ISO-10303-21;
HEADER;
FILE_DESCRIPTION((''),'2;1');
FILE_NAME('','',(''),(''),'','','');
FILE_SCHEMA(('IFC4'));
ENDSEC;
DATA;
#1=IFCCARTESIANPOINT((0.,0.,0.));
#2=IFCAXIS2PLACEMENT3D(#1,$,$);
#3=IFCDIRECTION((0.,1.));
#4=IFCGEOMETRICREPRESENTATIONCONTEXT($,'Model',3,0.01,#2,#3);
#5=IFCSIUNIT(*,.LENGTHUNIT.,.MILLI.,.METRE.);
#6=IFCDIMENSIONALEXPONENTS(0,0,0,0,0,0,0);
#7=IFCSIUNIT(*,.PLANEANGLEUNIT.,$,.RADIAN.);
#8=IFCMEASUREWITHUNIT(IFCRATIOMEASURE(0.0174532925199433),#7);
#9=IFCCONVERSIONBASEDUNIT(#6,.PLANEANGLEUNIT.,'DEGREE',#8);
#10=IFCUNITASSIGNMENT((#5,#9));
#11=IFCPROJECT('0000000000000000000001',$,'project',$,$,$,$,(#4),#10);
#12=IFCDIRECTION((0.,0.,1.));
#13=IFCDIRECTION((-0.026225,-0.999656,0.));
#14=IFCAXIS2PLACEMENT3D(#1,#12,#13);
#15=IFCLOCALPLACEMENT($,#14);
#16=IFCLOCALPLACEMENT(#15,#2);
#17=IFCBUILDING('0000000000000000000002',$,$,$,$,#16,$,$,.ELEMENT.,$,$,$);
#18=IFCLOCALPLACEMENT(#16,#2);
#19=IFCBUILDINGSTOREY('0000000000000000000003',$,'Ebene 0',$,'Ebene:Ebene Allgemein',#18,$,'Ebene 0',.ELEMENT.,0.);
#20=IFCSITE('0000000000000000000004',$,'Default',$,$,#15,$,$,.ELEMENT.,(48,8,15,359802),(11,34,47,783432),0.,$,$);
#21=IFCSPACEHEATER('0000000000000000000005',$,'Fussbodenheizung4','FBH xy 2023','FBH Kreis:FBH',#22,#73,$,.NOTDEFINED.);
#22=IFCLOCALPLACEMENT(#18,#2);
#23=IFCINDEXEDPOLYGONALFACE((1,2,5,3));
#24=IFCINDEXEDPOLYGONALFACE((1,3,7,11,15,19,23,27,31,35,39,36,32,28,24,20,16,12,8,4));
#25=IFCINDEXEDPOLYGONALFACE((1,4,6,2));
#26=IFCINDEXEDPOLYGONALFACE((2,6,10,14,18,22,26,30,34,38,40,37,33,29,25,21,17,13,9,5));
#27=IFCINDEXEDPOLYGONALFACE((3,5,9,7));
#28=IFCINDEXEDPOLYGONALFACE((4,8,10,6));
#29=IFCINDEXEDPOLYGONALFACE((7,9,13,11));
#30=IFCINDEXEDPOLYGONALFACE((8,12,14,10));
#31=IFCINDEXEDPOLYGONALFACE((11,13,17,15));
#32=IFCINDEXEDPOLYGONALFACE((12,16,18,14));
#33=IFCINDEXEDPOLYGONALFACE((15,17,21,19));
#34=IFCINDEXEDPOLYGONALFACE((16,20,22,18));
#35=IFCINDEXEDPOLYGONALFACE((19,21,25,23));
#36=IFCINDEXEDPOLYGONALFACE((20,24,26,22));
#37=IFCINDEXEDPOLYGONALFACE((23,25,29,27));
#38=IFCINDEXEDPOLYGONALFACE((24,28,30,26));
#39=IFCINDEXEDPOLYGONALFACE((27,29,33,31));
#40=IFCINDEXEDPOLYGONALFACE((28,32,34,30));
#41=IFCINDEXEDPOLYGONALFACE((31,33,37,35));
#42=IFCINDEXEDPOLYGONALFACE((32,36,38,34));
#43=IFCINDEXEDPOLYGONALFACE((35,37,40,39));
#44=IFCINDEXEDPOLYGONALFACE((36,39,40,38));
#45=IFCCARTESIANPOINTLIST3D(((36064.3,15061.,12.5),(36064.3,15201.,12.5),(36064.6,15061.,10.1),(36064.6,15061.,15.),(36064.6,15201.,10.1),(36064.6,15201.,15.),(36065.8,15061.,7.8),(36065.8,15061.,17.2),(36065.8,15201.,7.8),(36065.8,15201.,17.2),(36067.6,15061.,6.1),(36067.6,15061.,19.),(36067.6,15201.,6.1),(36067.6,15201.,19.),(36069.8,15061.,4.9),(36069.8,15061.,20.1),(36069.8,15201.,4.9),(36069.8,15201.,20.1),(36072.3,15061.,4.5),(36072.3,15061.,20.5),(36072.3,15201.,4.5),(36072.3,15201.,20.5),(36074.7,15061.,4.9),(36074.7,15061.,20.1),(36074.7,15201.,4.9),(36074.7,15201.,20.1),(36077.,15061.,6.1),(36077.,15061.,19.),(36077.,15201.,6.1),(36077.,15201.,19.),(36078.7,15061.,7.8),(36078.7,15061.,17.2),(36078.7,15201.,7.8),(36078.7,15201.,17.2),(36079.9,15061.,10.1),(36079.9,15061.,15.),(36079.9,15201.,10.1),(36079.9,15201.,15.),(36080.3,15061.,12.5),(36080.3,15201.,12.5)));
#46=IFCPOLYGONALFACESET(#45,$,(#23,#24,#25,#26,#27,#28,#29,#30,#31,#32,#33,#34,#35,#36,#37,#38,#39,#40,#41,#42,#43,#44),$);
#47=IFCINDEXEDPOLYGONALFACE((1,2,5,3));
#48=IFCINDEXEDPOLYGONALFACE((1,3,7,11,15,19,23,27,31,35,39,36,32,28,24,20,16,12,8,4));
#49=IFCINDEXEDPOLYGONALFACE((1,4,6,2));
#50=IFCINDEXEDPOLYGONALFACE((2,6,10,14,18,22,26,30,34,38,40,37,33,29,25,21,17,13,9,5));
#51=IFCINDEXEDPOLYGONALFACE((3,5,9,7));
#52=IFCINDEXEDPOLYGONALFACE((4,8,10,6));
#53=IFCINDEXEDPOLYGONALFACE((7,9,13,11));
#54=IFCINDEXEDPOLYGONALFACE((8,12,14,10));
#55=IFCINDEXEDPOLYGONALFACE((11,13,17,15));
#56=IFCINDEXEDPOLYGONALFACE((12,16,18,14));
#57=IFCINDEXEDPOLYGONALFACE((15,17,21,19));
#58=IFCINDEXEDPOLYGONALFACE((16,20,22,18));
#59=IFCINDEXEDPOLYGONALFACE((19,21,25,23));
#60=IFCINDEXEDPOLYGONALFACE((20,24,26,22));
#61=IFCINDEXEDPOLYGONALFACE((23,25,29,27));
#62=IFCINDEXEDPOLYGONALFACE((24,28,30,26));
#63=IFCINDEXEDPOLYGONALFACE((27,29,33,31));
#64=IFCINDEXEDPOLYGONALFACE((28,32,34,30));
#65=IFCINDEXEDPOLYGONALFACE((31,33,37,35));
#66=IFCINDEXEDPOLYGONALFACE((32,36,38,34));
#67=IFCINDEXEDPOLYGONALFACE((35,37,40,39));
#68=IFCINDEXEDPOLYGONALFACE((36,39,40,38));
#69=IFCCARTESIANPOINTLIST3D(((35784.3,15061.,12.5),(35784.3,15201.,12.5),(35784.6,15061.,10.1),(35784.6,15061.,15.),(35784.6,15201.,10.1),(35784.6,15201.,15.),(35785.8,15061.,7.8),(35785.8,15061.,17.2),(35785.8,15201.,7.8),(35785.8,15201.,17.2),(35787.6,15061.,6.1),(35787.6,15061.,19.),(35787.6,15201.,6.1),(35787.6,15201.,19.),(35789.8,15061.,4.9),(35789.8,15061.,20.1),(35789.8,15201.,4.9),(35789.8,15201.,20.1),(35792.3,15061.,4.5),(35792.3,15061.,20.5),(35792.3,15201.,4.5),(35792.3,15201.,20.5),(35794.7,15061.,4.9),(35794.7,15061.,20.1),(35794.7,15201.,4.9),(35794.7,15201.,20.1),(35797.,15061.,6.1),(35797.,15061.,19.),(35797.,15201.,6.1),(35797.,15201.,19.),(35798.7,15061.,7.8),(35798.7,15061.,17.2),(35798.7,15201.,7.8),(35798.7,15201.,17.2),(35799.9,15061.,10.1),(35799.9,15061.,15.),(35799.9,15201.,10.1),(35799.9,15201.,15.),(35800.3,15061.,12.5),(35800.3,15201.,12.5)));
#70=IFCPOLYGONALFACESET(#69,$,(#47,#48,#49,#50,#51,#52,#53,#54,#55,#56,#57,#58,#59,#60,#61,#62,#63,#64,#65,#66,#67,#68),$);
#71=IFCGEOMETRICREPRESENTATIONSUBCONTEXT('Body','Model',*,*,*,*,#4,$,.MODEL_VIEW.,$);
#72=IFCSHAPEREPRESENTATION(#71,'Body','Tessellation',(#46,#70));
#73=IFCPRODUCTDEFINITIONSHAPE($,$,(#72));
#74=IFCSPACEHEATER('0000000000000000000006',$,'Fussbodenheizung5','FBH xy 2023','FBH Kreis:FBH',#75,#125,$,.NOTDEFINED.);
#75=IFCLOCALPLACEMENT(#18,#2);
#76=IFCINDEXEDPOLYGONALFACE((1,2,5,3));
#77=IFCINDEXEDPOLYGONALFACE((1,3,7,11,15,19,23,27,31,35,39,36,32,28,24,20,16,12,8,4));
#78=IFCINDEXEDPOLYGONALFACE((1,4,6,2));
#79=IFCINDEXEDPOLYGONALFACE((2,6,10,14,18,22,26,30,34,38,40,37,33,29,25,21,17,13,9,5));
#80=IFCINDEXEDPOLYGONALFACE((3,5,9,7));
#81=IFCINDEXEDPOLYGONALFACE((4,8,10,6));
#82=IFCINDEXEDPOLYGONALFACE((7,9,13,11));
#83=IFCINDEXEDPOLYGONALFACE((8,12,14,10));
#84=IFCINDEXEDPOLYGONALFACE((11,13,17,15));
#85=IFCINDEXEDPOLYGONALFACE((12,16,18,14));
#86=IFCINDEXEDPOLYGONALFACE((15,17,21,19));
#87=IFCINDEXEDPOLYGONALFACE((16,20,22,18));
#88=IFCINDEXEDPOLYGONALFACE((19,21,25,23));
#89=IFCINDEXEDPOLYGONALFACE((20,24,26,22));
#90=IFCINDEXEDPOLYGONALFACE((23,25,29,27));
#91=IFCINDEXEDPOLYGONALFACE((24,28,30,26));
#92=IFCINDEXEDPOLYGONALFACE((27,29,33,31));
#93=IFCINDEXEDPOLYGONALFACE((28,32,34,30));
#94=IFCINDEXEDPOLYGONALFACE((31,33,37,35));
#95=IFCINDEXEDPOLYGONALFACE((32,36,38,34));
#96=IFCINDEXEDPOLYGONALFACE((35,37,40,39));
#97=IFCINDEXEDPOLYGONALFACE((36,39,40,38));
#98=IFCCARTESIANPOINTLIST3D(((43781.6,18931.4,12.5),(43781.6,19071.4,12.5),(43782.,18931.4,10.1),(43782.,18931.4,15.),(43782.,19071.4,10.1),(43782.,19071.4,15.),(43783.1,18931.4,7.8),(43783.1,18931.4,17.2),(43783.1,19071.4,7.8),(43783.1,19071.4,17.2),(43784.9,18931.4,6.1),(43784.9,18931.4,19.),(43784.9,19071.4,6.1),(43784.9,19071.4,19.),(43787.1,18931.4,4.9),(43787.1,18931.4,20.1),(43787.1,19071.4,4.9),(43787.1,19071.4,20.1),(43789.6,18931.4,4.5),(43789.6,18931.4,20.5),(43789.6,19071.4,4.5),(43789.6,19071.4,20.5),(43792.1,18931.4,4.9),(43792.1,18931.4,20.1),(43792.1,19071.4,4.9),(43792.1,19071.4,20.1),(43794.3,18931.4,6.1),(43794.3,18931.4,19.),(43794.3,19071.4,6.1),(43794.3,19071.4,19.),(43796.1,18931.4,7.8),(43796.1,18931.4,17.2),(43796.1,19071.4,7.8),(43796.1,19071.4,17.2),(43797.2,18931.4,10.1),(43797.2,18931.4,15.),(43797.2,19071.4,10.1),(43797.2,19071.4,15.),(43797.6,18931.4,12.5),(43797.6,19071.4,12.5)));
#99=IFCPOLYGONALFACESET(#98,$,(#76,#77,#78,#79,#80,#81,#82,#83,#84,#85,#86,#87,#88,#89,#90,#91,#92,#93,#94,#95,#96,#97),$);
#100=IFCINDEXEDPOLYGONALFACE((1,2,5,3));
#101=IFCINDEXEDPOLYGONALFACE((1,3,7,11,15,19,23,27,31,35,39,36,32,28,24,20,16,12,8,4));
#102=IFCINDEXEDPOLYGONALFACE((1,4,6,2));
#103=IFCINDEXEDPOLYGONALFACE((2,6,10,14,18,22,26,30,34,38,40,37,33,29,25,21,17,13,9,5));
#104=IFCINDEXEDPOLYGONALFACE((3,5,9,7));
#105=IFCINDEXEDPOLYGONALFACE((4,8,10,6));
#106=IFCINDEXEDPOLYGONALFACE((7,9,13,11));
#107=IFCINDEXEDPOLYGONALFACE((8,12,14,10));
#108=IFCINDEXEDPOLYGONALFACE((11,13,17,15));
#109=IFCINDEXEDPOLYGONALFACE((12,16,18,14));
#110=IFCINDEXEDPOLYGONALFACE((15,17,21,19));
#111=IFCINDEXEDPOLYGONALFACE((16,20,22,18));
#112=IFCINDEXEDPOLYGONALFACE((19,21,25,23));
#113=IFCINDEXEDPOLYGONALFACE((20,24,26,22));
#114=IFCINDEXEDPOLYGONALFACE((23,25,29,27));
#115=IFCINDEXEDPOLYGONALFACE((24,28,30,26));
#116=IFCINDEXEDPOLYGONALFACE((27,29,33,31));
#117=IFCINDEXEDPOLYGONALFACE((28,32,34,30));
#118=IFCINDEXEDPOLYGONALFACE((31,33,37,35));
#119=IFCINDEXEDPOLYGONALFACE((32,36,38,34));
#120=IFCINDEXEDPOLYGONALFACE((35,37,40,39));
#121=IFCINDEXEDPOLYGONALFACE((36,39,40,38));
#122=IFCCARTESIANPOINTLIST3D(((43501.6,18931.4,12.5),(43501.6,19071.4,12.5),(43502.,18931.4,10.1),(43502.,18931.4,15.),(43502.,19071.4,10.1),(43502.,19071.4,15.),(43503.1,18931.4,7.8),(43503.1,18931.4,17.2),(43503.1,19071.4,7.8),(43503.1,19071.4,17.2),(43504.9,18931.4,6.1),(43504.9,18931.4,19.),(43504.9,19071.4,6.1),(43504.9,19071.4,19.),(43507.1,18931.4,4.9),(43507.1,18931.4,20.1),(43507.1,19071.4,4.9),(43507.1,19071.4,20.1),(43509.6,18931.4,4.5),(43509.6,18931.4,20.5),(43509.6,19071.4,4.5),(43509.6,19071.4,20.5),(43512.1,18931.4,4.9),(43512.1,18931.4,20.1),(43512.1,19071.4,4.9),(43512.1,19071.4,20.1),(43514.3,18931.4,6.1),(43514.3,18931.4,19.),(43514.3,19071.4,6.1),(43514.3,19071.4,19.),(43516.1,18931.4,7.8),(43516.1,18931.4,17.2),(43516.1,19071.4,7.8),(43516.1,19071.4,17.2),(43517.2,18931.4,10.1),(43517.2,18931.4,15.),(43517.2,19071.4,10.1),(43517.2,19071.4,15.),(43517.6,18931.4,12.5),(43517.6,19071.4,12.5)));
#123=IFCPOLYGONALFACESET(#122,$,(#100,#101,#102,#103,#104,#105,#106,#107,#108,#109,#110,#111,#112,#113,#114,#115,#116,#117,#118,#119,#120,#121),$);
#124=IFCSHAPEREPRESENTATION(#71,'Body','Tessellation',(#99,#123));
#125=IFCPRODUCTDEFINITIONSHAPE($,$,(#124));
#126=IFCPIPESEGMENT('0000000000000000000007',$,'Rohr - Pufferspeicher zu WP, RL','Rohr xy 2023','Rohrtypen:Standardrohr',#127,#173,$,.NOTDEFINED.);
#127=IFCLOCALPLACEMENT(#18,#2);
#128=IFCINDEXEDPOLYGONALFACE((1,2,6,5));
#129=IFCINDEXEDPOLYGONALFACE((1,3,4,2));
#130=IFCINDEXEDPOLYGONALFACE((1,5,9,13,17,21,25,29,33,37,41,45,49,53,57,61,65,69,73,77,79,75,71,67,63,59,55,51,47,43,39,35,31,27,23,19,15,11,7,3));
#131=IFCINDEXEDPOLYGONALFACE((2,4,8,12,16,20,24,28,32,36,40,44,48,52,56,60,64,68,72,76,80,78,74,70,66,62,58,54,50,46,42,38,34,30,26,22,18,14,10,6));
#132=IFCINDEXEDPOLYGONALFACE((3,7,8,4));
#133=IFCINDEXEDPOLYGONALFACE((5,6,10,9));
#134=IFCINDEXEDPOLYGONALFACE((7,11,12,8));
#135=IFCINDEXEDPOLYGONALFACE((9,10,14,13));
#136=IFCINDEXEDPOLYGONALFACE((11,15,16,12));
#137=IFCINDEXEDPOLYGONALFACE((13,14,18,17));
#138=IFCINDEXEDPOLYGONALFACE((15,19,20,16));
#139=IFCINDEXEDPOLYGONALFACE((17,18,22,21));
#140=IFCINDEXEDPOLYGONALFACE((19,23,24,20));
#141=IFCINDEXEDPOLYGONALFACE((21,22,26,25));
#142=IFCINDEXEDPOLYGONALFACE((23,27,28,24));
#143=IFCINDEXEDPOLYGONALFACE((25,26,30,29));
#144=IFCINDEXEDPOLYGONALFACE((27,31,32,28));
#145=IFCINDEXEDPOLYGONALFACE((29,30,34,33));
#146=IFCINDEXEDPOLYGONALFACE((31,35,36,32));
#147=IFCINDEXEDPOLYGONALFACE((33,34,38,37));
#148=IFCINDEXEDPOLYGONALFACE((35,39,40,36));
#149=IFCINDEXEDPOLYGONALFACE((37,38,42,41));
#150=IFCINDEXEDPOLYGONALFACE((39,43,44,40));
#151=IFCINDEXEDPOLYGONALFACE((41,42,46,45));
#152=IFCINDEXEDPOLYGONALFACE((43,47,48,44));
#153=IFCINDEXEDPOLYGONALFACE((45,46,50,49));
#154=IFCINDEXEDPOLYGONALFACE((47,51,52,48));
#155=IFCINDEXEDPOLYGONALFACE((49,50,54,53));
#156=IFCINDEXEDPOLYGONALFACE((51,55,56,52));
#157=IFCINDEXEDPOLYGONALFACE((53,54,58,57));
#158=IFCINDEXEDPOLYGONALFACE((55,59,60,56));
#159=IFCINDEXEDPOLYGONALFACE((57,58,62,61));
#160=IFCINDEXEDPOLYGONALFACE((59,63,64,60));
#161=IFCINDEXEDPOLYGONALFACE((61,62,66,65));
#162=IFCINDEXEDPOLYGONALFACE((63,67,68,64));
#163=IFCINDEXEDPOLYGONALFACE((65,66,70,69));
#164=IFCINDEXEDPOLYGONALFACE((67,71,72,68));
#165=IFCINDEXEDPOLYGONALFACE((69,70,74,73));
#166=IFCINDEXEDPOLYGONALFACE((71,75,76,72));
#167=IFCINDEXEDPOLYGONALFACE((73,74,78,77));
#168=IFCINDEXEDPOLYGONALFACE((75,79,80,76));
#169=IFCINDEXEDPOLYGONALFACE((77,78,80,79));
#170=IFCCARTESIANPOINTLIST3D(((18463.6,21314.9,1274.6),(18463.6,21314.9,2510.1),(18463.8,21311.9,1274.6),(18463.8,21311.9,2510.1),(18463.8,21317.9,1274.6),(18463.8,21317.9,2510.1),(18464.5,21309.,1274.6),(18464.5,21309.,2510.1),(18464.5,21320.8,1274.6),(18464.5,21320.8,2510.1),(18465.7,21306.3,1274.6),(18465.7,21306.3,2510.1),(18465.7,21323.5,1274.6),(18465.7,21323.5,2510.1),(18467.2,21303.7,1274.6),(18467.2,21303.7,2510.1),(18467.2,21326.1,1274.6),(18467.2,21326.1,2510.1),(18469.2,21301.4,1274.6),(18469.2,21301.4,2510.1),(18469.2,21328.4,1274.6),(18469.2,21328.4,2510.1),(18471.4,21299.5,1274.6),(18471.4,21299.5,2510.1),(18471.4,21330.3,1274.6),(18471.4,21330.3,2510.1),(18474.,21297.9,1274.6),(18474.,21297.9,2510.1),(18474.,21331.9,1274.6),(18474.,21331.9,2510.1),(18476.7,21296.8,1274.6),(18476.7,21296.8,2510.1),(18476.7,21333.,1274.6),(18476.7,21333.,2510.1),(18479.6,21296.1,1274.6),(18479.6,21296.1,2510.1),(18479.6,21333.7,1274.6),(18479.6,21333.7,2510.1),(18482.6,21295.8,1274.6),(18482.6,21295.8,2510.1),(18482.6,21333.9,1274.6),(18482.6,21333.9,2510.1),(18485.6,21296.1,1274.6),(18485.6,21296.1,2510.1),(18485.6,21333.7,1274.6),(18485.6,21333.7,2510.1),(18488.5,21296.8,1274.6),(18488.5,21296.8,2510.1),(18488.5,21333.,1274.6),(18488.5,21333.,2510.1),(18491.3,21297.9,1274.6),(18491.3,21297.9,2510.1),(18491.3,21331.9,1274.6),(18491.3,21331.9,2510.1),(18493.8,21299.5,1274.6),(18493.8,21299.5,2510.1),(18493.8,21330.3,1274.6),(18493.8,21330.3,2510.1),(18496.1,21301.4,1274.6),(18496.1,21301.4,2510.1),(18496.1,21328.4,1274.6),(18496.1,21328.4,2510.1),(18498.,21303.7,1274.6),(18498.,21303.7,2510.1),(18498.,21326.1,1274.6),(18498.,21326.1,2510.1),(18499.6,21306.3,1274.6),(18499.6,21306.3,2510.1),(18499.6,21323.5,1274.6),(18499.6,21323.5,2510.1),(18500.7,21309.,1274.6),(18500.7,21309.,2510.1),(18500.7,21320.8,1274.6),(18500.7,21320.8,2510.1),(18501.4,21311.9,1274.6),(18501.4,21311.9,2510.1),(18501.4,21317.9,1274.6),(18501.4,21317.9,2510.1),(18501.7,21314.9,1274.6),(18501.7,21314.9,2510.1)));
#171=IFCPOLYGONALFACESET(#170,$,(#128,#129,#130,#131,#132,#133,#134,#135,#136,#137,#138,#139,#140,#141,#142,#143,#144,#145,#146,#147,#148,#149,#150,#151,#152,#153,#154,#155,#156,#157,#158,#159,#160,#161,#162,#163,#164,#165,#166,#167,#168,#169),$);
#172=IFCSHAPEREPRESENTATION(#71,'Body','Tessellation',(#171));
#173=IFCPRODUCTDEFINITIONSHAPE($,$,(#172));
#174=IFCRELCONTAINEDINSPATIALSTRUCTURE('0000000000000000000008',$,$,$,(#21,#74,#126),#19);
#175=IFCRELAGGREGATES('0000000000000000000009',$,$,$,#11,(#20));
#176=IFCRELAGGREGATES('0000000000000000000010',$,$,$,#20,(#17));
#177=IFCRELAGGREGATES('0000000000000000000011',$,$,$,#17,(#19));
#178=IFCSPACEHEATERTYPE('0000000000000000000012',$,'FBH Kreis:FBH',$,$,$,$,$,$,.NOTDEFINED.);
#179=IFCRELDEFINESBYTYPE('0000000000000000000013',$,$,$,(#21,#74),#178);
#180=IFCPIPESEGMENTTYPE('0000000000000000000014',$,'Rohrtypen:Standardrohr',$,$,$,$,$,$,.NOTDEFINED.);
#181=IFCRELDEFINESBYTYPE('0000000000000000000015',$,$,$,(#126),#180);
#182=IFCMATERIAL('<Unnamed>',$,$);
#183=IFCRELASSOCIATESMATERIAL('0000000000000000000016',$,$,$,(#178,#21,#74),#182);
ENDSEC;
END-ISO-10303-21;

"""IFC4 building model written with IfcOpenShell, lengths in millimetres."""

from ifc_helpers import new_model, entity, si_unit, converted_unit, direction, frame, origin, place, context, subcontext, project, spatial, indexed_curve, outline, extrude, source, transform, mapped, material, type_object, type_shapes, element, save


model = new_model("IFC4")

# Units and contexts
model_context = context("Model", 3, precision=0.01, world=origin(), true_north=direction((0.0, 1.0)))
body_context = subcontext(model_context, "Body", "Model", "MODEL_VIEW")
ifc_project = project(units=[si_unit("LENGTHUNIT", "METRE", prefix="MILLI"), converted_unit("PLANEANGLEUNIT", "DEGREE", entity("IfcRatioMeasure", 0.0174532925199433), si_unit("PLANEANGLEUNIT", "RADIAN"), dimensions=[0, 0, 0, 0, 0, 0, 0])], contexts=[model_context])

# Site, building, storey
site_placement = place(None, frame((0.0, 0.0, 0.0), z_axis=(0.0, 0.0, 1.0), x_axis=(-0.026225, -0.999656, 0.0)))
site = spatial("IfcSite", under=ifc_project, at=site_placement, Name="Default", CompositionType="ELEMENT", RefLatitude=(48, 8, 15, 359802), RefLongitude=(11, 34, 47, 783432), RefElevation=0.0)
building_placement = place(site_placement, origin())
building = spatial("IfcBuilding", under=site, at=building_placement, CompositionType="ELEMENT")
storey_placement = place(building_placement, origin())
storey = spatial("IfcBuildingStorey", under=building, at=storey_placement, Name="Ebene 0", ObjectType="Ebene:Ebene Allgemein", LongName="Ebene 0", CompositionType="ELEMENT", Elevation=0.0)

# Space heaters
ifc_material = material(Name="<Unnamed>")
space_heater_type = type_object("IfcSpaceHeaterType", Name="FBH Kreis:FBH", PredefinedType="NOTDEFINED", material=ifc_material)
shared_shape = source(origin(), body_context, "Body", "SweptSolid", [
    extrude(outline(indexed_curve([(8.0, 0.0), (7.6, 2.5), (6.5, 4.7), (4.7, 6.5), (2.5, 7.6), (0.0, 8.0), (-2.5, 7.6), (-4.7, 6.5), (-6.5, 4.7), (-7.6, 2.5), (-8.0, 0.0), (-7.6, -2.5), (-6.5, -4.7), (-4.7, -6.5), (-2.5, -7.6), (0.0, -8.0), (2.5, -7.6), (4.7, -6.5), (6.5, -4.7), (7.6, -2.5), (8.0, 0.0)], self_intersect=False)), frame((140.0, -1621.8, -83.0), z_axis=(0.0, 1.0, 0.0), x_axis=(1.0, 0.0, 0.0)), (0.0, 0.0, 1.0), 140.0),
    extrude(outline(indexed_curve([(8.0, 0.0), (7.6, 2.5), (6.5, 4.7), (4.7, 6.5), (2.5, 7.6), (0.0, 8.0), (-2.5, 7.6), (-4.7, 6.5), (-6.5, 4.7), (-7.6, 2.5), (-8.0, 0.0), (-7.6, -2.5), (-6.5, -4.7), (-4.7, -6.5), (-2.5, -7.6), (0.0, -8.0), (2.5, -7.6), (4.7, -6.5), (6.5, -4.7), (7.6, -2.5), (8.0, 0.0)], self_intersect=False)), frame((-140.0, -1621.8, -83.0), z_axis=(0.0, 1.0, 0.0), x_axis=(1.0, 0.0, 0.0)), (0.0, 0.0, 1.0), 140.0),
])
type_shapes(space_heater_type, [shared_shape])
for number, where, name in (
    (1, (35932.3, 16682.8, 95.5), "Fussbodenheizung4"),
    (2, (43649.6, 20553.2, 95.5), "Fussbodenheizung5"),
):
    element("IfcSpaceHeater", number, at=place(storey_placement, frame(where)), inside=storey, type_object=space_heater_type, material=ifc_material, Name=name, Description="FBH xy 2023", ObjectType="FBH Kreis:FBH", PredefinedType="NOTDEFINED", context=body_context, shape_type="MappedRepresentation", body=[
        mapped(shared_shape, transform((0.0, 0.0, 0.0), scale=1.0)),
    ])

# Pipe segment
pipe_segment_type = type_object("IfcPipeSegmentType", Name="Rohrtypen:Standardrohr", PredefinedType="NOTDEFINED")
pipe_segment_1_placement = place(storey_placement, origin())
element("IfcPipeSegment", 3, at=pipe_segment_1_placement, inside=storey, type_object=pipe_segment_type, Name="Rohr - Pufferspeicher zu WP, RL", Description="Rohr xy 2023", ObjectType="Rohrtypen:Standardrohr", PredefinedType="NOTDEFINED", context=body_context, shape_type="SweptSolid", body=[
    extrude(outline(indexed_curve([(19.1, 0.0), (18.8, 3.0), (18.1, 5.9), (17.0, 8.6), (15.4, 11.2), (13.5, 13.5), (11.2, 15.4), (8.6, 17.0), (5.9, 18.1), (3.0, 18.8), (0.0, 19.1), (-3.0, 18.8), (-5.9, 18.1), (-8.6, 17.0), (-11.2, 15.4), (-13.5, 13.5), (-15.4, 11.2), (-17.0, 8.6), (-18.1, 5.9), (-18.8, 3.0), (-19.1, 0.0), (-18.8, -3.0), (-18.1, -5.9), (-17.0, -8.6), (-15.4, -11.2), (-13.5, -13.5), (-11.2, -15.4), (-8.6, -17.0), (-5.9, -18.1), (-3.0, -18.8), (0.0, -19.1), (3.0, -18.8), (5.9, -18.1), (8.6, -17.0), (11.2, -15.4), (13.5, -13.5), (15.4, -11.2), (17.0, -8.6), (18.1, -5.9), (18.8, -3.0), (19.1, 0.0)], self_intersect=False)), frame((18482.6, 21314.9, 1274.6), z_axis=(0.0, 0.0, 1.0), x_axis=(-1.0, 0.0, 0.0)), (0.0, 0.0, 1.0), 1235.5),
])

save(model, "model.ifc")
